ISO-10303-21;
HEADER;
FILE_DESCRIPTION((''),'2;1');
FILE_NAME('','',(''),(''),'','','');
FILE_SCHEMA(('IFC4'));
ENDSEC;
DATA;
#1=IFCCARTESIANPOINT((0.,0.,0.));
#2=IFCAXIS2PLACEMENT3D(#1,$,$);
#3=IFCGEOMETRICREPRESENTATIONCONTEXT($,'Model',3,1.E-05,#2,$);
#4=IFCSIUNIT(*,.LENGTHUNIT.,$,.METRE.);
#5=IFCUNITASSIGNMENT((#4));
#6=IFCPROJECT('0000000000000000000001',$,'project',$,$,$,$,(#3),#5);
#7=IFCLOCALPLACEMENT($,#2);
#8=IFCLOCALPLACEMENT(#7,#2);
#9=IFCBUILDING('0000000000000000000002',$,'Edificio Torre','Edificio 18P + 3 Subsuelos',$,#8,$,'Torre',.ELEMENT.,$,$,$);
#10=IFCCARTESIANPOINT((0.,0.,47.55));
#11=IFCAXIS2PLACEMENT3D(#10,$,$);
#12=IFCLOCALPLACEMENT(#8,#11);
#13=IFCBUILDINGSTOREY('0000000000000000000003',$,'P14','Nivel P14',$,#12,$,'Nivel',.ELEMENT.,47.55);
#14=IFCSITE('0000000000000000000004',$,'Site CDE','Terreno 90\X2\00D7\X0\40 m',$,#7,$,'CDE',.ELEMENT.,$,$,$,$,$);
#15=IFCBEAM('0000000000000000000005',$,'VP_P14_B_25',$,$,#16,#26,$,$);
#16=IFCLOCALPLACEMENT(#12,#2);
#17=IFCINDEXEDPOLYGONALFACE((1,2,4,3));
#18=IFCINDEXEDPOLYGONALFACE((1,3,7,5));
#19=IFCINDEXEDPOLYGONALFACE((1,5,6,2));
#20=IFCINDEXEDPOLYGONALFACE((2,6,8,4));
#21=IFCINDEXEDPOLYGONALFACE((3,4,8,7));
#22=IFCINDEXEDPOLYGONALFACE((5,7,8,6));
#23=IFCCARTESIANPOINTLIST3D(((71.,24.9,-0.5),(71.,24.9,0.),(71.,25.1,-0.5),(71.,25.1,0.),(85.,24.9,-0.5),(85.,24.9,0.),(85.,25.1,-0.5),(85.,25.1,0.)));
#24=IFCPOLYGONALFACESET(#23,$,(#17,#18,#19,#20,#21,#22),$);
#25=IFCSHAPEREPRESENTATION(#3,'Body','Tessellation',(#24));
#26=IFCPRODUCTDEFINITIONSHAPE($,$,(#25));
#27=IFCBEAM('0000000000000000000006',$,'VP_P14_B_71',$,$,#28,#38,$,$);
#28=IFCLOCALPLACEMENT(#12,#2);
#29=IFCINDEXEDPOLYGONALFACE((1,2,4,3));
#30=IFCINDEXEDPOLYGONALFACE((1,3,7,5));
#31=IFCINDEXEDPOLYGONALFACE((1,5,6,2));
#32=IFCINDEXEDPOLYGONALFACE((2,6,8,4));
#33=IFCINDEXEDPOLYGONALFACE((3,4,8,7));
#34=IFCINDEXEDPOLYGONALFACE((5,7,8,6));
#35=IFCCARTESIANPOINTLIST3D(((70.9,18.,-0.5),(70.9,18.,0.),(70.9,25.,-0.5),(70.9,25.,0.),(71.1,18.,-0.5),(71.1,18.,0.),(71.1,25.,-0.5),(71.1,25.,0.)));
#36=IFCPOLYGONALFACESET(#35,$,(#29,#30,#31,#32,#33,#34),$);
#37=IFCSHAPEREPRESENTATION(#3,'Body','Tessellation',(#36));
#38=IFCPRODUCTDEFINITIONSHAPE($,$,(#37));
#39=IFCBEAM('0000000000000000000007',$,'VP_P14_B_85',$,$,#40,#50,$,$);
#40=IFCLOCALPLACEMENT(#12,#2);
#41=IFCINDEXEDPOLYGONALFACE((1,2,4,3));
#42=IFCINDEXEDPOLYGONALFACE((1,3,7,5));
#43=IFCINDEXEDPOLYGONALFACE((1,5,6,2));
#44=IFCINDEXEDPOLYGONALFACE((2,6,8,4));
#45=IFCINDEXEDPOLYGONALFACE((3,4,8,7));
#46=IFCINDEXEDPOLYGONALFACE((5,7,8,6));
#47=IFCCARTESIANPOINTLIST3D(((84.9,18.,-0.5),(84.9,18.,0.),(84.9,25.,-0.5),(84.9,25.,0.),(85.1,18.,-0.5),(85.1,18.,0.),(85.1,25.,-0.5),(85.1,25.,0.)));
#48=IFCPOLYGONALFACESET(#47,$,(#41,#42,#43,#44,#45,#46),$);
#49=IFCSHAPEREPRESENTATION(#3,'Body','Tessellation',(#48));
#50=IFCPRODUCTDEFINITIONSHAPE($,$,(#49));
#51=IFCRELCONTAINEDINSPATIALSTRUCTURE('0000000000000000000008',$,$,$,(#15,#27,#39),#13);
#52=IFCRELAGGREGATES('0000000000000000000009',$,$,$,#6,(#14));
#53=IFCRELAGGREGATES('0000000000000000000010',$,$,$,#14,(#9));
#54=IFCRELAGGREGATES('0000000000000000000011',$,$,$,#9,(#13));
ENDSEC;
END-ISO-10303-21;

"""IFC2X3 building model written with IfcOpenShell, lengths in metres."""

from ifc_helpers import new_model, si_unit, frame, origin, origin_2d, place, context, project, spatial, rectangle, extrude, element, save


model = new_model("IFC2X3")

# Units and contexts
model_context = context("Model", 3, precision=1e-05, world=origin())
ifc_project = project(units=[si_unit("LENGTHUNIT", "METRE")], contexts=[model_context])

# Site, building, storey
site_placement = place(None, origin())
site = spatial("IfcSite", under=ifc_project, at=site_placement, Name="Site CDE", Description="Terreno 90×40 m", LongName="CDE", CompositionType="ELEMENT")
building_placement = place(site_placement, origin())
building = spatial("IfcBuilding", under=site, at=building_placement, Name="Edificio Torre", Description="Edificio 18P + 3 Subsuelos", LongName="Torre", CompositionType="ELEMENT")
storey_placement = place(building_placement, frame((0.0, 0.0, 47.55)))
storey = spatial("IfcBuildingStorey", under=building, at=storey_placement, Name="P14", Description="Nivel P14", LongName="Nivel", CompositionType="ELEMENT", Elevation=47.55)

# Beams
for number, where, name in (
    (1, (78.0, 25.0, -0.5), "VP_P14_B_25"),
):
    element("IfcBeam", number, at=place(storey_placement, frame(where)), inside=storey, Name=name, context=model_context, shape_type="SweptSolid", body=[
        extrude(rectangle(XDim=14.0, YDim=0.2, at=origin_2d()), origin(), (0.0, 0.0, 1.0), 0.5),
    ])
for number, where, name in (
    (2, (71.0, 21.5, -0.5), "VP_P14_B_71"),
    (3, (85.0, 21.5, -0.5), "VP_P14_B_85"),
):
    element("IfcBeam", number, at=place(storey_placement, frame(where)), inside=storey, Name=name, context=model_context, shape_type="SweptSolid", body=[
        extrude(rectangle(XDim=0.2, YDim=7.0, at=origin_2d()), origin(), (0.0, 0.0, 1.0), 0.5),
    ])

save(model, "model.ifc")
